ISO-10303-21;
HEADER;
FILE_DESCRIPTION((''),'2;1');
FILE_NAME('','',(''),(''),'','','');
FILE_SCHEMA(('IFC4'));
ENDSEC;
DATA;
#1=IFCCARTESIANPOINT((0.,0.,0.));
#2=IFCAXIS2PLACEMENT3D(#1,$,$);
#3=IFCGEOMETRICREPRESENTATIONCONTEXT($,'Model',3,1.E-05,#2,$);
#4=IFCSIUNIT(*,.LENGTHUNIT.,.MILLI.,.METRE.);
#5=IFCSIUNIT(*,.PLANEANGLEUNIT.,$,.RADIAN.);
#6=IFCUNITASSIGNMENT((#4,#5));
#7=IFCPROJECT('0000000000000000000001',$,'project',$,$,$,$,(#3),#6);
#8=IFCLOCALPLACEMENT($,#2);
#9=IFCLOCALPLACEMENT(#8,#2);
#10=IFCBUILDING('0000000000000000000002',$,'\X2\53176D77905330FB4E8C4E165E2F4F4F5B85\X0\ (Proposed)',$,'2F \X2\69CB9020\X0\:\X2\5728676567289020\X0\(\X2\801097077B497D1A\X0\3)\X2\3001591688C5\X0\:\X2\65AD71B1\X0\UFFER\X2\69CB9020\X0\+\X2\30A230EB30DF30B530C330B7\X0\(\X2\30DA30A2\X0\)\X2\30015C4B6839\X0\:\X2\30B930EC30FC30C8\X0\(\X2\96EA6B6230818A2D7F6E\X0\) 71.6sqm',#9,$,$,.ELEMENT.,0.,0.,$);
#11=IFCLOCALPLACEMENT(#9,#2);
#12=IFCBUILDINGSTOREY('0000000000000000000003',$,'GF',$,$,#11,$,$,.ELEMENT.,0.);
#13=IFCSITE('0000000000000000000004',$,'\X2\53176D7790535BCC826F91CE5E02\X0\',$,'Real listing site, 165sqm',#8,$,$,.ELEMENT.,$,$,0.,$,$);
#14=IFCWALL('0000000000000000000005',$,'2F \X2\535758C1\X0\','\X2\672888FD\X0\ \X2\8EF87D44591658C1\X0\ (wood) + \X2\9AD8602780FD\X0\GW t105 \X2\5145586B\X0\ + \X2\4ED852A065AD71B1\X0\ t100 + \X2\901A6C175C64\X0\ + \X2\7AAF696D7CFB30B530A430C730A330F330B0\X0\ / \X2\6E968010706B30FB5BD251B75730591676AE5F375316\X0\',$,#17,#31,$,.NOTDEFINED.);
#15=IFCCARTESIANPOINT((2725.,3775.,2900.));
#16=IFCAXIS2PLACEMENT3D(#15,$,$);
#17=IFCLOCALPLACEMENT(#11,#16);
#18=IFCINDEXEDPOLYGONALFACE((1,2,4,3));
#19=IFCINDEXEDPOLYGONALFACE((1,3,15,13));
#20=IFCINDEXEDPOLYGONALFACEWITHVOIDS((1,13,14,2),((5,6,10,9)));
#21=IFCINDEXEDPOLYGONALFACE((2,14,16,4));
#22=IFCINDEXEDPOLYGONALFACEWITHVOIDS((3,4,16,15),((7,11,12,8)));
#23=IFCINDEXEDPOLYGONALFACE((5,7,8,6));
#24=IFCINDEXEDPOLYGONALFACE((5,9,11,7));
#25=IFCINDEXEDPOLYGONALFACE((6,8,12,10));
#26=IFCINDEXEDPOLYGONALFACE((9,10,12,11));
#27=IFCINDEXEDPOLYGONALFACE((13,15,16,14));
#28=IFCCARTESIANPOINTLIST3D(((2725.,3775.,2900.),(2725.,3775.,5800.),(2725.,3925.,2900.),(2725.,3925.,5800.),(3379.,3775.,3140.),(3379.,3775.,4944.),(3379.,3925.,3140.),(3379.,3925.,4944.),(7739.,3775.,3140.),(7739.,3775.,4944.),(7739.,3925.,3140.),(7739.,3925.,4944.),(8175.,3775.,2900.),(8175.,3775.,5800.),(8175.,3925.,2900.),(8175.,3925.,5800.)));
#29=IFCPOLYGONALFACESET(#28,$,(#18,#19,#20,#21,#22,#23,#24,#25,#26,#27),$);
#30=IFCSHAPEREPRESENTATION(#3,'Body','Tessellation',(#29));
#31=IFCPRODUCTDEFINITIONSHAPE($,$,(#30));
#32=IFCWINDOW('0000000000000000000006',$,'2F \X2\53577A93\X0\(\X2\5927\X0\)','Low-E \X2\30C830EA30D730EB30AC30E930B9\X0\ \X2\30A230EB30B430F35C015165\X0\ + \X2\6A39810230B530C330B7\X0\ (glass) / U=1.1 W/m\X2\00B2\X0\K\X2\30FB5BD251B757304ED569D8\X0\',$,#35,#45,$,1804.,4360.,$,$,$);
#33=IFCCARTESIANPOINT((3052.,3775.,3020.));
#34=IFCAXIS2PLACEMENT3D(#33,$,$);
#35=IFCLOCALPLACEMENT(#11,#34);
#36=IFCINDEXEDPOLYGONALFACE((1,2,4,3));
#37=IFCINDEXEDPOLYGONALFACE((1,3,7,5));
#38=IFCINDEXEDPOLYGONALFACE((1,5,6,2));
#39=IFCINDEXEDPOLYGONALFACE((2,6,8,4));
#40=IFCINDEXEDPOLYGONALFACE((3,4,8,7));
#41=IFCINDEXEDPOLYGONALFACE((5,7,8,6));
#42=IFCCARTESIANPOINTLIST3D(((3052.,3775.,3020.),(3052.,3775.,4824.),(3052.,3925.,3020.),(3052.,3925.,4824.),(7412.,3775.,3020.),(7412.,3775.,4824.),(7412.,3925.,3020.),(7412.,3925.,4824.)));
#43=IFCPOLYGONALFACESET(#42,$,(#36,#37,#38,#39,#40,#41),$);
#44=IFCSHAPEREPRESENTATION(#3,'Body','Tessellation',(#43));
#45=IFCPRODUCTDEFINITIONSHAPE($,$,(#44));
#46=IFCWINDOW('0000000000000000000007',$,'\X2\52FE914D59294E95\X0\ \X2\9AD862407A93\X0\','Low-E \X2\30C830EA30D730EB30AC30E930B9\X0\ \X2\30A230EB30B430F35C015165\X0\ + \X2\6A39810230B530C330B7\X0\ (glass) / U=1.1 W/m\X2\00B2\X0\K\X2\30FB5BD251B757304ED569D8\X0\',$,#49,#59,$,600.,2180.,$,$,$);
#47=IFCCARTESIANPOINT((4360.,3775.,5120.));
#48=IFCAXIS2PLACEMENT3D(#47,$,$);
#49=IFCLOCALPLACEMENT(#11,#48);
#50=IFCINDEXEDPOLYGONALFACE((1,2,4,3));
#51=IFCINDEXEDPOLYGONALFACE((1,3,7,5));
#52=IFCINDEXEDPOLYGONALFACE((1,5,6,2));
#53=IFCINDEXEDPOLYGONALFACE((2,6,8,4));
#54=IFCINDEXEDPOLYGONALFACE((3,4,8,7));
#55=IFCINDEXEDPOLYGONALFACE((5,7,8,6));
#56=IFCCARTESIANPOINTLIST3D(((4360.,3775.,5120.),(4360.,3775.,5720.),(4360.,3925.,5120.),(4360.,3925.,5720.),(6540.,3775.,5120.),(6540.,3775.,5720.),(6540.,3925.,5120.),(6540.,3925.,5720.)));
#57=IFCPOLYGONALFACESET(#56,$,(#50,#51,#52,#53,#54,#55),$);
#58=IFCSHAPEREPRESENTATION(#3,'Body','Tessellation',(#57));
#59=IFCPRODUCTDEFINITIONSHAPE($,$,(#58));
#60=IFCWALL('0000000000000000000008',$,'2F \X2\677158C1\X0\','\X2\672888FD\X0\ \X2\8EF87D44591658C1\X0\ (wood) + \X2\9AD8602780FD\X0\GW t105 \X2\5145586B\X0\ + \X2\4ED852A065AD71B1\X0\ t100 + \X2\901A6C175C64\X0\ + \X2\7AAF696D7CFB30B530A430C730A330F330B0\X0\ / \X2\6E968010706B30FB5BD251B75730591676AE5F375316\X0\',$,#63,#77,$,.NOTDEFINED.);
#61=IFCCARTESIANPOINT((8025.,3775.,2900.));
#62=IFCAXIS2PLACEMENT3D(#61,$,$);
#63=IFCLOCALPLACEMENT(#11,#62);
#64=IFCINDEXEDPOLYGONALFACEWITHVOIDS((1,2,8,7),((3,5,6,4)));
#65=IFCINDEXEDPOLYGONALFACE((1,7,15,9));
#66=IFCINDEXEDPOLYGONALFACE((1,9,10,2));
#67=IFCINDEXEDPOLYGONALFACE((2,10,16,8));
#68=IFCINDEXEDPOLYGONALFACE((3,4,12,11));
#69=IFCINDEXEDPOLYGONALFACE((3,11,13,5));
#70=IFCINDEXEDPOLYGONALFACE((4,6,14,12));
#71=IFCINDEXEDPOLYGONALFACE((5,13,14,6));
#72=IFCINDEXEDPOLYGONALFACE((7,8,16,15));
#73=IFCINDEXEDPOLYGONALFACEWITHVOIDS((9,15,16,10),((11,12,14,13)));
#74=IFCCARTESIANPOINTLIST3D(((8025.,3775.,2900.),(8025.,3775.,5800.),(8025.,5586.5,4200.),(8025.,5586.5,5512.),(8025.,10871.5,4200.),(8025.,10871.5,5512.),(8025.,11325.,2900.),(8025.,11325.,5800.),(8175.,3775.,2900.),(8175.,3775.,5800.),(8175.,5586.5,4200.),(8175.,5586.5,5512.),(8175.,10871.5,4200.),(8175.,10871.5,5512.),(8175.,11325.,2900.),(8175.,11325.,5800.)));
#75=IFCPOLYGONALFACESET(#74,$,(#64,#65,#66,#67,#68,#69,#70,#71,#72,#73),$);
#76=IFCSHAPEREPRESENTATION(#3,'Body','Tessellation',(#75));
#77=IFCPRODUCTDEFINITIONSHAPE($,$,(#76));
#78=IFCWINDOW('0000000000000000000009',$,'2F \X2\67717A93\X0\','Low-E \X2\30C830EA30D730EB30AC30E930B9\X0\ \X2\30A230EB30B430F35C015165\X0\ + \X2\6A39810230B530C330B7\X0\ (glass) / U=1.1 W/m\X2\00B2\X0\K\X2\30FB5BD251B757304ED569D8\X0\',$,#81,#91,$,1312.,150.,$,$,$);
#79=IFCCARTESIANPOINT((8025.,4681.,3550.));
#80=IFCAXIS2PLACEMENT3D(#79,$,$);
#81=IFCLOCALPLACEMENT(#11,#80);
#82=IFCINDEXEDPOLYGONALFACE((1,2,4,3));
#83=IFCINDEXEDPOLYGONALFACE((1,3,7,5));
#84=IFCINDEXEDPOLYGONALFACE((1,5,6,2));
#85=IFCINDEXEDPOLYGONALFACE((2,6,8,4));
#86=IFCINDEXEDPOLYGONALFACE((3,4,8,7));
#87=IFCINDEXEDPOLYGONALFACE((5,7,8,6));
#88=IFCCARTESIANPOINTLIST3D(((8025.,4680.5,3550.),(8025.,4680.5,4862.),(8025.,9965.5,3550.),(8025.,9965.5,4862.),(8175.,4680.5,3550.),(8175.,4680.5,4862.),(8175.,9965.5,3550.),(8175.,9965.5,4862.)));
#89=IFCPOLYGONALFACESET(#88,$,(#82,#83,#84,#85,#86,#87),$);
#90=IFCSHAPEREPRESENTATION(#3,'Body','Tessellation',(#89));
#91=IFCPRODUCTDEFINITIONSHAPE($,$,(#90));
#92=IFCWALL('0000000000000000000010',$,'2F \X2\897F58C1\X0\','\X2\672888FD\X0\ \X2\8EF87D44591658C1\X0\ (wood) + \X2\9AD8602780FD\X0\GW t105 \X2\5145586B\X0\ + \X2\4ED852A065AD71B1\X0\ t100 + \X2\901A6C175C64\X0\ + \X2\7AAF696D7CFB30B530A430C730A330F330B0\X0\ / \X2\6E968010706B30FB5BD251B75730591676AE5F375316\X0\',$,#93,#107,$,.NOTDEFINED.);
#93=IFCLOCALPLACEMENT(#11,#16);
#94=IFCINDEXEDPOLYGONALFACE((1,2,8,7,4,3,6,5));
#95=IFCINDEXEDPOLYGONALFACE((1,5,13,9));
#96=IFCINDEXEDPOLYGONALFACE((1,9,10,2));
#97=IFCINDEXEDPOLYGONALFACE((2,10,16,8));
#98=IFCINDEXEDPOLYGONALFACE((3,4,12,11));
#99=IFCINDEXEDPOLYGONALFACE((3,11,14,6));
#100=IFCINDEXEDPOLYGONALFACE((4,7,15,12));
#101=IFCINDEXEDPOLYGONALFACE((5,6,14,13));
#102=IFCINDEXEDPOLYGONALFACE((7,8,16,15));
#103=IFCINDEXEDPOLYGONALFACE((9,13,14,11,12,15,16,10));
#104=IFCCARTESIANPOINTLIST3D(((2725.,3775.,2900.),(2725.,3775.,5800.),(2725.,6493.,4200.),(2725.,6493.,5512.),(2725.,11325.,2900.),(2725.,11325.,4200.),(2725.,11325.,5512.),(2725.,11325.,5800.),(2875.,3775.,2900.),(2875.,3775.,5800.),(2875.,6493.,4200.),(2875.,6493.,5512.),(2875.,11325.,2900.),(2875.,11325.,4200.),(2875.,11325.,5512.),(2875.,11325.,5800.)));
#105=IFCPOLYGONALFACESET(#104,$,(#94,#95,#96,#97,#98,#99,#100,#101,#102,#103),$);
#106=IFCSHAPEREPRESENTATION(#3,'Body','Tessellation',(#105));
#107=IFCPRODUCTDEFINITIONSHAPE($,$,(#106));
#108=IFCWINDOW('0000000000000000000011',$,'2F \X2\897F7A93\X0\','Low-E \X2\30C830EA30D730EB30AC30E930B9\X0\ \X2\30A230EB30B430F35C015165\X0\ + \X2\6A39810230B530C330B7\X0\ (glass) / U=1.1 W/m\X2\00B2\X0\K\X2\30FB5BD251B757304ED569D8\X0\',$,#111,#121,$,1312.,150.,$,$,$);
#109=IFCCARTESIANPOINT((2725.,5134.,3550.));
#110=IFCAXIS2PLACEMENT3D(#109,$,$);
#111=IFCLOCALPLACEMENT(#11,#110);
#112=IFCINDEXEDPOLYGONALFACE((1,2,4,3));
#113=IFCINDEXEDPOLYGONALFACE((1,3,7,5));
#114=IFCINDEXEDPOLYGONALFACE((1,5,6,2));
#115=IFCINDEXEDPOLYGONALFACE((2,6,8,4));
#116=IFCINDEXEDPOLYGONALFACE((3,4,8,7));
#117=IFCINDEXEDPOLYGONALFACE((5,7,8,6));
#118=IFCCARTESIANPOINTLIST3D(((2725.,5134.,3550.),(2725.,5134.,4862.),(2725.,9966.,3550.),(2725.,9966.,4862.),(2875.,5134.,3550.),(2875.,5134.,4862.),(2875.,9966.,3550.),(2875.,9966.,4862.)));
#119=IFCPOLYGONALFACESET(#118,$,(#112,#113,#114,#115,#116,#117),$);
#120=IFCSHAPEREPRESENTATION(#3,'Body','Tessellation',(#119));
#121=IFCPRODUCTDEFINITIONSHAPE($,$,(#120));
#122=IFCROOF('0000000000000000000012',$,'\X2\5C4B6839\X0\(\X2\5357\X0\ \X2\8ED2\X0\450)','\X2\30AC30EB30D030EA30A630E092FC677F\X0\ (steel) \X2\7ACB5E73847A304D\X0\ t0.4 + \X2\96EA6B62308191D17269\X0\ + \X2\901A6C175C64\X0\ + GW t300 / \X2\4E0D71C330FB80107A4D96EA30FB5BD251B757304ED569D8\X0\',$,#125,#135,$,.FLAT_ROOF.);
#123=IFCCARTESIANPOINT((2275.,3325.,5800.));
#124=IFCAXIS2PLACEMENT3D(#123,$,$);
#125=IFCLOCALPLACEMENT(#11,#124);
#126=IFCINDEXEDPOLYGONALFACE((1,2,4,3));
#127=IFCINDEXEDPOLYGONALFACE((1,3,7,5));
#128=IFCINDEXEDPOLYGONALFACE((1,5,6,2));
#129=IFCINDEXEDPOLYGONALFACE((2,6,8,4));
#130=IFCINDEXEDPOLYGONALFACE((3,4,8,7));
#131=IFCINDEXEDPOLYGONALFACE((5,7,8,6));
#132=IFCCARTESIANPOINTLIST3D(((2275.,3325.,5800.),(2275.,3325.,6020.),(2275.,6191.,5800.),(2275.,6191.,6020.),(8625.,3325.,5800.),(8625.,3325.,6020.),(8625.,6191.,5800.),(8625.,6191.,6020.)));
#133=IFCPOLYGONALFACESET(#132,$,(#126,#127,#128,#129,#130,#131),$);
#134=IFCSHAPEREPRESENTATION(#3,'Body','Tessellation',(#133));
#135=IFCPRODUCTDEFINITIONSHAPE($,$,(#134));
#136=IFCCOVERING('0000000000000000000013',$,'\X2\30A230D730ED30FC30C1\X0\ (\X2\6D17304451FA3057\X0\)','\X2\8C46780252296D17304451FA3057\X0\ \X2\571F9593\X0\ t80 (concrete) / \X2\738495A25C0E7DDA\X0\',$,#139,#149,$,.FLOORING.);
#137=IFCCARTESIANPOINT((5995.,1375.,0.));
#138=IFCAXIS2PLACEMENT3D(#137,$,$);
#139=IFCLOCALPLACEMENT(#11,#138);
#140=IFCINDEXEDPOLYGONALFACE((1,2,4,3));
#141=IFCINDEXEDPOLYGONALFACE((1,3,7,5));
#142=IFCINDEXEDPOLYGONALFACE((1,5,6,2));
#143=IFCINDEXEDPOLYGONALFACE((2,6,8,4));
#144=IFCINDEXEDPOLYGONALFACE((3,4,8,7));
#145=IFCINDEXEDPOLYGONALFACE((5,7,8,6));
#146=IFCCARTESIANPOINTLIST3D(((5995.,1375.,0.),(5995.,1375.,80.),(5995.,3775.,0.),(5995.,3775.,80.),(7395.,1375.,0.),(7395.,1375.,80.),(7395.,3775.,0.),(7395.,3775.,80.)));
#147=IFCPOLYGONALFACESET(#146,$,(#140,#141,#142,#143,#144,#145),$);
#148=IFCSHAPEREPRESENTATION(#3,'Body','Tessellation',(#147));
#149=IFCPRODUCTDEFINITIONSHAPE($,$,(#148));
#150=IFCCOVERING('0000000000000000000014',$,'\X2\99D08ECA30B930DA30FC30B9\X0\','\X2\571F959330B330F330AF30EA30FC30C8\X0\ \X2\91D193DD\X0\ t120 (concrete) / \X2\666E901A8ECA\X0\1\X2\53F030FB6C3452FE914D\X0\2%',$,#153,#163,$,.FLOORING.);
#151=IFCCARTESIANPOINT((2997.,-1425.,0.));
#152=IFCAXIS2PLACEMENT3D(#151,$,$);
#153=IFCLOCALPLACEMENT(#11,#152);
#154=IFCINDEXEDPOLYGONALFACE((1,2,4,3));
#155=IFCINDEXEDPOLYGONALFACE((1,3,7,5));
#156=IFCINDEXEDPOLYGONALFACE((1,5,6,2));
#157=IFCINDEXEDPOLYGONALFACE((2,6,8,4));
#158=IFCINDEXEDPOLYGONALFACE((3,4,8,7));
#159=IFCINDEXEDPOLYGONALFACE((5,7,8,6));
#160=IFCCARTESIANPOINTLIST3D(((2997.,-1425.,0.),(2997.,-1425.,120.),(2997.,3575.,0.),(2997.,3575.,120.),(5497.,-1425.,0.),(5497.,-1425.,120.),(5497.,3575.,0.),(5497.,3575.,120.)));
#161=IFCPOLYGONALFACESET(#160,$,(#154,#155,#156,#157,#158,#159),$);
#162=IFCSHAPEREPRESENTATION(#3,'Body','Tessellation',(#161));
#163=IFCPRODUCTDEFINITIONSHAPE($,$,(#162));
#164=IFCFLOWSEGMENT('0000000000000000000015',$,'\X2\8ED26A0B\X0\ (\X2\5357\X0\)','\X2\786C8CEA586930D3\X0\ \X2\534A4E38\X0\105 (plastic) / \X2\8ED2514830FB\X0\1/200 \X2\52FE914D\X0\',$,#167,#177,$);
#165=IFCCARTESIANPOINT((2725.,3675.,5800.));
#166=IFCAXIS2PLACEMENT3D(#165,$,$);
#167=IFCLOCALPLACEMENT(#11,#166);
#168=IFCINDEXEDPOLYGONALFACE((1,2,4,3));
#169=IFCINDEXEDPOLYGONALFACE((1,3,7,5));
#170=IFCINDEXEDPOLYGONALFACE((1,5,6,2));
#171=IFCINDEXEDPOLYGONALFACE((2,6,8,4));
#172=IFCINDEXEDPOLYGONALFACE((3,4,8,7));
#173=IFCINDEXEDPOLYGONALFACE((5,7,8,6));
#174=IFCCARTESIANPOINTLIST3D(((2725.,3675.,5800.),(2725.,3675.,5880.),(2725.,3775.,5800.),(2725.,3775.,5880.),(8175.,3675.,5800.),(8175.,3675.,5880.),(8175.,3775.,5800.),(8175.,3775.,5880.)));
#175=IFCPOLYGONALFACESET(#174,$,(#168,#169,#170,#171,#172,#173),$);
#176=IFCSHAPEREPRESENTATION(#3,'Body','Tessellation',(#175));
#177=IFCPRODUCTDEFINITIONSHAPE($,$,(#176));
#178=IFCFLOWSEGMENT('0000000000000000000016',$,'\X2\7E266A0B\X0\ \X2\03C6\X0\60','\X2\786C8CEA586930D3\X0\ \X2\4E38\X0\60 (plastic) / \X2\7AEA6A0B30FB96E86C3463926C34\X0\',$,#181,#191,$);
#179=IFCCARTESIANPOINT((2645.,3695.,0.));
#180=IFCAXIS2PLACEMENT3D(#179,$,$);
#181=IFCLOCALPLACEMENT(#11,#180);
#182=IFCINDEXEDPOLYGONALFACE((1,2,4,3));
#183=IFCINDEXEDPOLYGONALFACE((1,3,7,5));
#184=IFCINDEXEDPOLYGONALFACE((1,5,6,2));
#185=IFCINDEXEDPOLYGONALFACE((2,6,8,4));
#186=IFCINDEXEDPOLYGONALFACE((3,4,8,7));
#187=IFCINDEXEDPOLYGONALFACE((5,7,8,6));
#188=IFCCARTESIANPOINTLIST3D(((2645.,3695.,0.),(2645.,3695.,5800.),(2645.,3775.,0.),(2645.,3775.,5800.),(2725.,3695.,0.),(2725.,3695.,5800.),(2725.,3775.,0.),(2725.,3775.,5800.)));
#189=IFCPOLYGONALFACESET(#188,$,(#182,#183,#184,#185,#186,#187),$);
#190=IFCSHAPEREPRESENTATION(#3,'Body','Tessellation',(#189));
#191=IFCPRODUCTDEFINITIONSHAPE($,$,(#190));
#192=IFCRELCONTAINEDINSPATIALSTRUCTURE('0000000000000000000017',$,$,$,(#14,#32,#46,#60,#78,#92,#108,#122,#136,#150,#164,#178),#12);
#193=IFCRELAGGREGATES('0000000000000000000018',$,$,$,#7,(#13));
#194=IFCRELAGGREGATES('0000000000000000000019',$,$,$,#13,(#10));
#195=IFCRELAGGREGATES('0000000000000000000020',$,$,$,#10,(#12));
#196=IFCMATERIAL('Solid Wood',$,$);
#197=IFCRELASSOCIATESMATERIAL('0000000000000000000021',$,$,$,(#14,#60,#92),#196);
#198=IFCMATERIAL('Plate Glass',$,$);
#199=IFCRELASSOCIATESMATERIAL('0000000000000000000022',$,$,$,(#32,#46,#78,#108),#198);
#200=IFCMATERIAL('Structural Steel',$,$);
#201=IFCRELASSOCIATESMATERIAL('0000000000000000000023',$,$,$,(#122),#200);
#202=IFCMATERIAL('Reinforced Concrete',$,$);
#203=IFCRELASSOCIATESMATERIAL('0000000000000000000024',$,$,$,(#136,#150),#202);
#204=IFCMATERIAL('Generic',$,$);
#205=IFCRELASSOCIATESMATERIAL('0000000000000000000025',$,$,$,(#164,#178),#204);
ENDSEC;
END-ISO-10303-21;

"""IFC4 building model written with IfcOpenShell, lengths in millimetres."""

from ifc_helpers import new_model, si_unit, frame, frame_2d, origin, place, context, project, spatial, rectangle, extrude, material, element, fill, save


model = new_model("IFC4")

# Units and contexts
model_context = context("Model", 3, precision=1e-05, world=origin())
ifc_project = project(units=[si_unit("LENGTHUNIT", "METRE", prefix="MILLI"), si_unit("PLANEANGLEUNIT", "RADIAN")], contexts=[model_context])

# Site, building, storey
site_placement = place(None, origin())
site = spatial("IfcSite", under=ifc_project, at=site_placement, Name="北海道富良野市", ObjectType="Real listing site, 165sqm", CompositionType="ELEMENT", RefElevation=0.0)
building_placement = place(site_placement, origin())
building = spatial("IfcBuilding", under=site, at=building_placement, Name="北海道・二世帯住宅 (Proposed)", ObjectType="2F 構造:在来木造(耐震等級3)、外装:断熱UFFER構造+アルミサッシ(ペア)、屋根:スレート(雪止め設置) 71.6sqm", CompositionType="ELEMENT", ElevationOfRefHeight=0.0, ElevationOfTerrain=0.0)
storey_placement = place(building_placement, origin())
storey = spatial("IfcBuildingStorey", under=building, at=storey_placement, Name="GF", CompositionType="ELEMENT", Elevation=0.0)

# Shared definitions
ifc_material_1 = material(Name="Solid Wood")

# Shared definitions
ifc_material_2 = material(Name="Reinforced Concrete")

# Shared definitions
ifc_material_3 = material(Name="Plate Glass")

# Wall, openings, windows
wall_1_placement = place(storey_placement, frame((2725.0, 3775.0, 2900.0)))
wall_1 = element("IfcWall", 1, at=wall_1_placement, inside=storey, material=ifc_material_1, Name="2F 南壁", Description="木製 軸組外壁 (wood) + 高性能GW t105 充填 + 付加断熱 t100 + 通気層 + 窯業系サイディング / 準耐火・寒冷地外皮強化", PredefinedType="NOTDEFINED", context=model_context, shape_type="SweptSolid", body=[
    extrude(rectangle(XDim=5450.0, YDim=150.0, at=frame_2d((2725.0, 75.0))), frame((2725.0, 3775.0, 2900.0)), (0.0, 0.0, 1.0), 2900.0),
])
opening_1_placement = place(storey_placement, frame((3052.0, 3775.0, 3020.0)))
opening_1 = element("IfcOpeningElement", 2, at=opening_1_placement, cuts=wall_1, PredefinedType="NOTDEFINED", context=model_context, shape_type="SweptSolid", body=[
    extrude(rectangle(XDim=4360.0, YDim=150.0, at=frame_2d((2180.0, 75.0))), frame((3052.0, 3775.0, 3020.0)), (0.0, 0.0, 1.0), 1804.0),
])
opening_2_placement = place(storey_placement, frame((4360.0, 3775.0, 5120.0)))
opening_2 = element("IfcOpeningElement", 3, at=opening_2_placement, cuts=wall_1, PredefinedType="NOTDEFINED", context=model_context, shape_type="SweptSolid", body=[
    extrude(rectangle(XDim=2180.0, YDim=150.0, at=frame_2d((1090.0, 75.0))), frame((4360.0, 3775.0, 5120.0)), (0.0, 0.0, 1.0), 600.0),
])
window_1_placement = place(storey_placement, frame((3052.0, 3775.0, 3020.0)))
window_1 = element("IfcWindow", 4, at=window_1_placement, inside=storey, material=ifc_material_3, Name="2F 南窓(大)", Description="Low-E トリプルガラス アルゴン封入 + 樹脂サッシ (glass) / U=1.1 W/m²K・寒冷地仕様", OverallHeight=1804.0, OverallWidth=4360.0, context=model_context, shape_type="SweptSolid", body=[
    extrude(rectangle(XDim=4360.0, YDim=150.0, at=frame_2d((2180.0, 75.0))), frame((3052.0, 3775.0, 3020.0)), (0.0, 0.0, 1.0), 1804.0),
])
fill(opening_1, window_1)
window_2_placement = place(storey_placement, frame((4360.0, 3775.0, 5120.0)))
window_2 = element("IfcWindow", 5, at=window_2_placement, inside=storey, material=ifc_material_3, Name="勾配天井 高所窓", Description="Low-E トリプルガラス アルゴン封入 + 樹脂サッシ (glass) / U=1.1 W/m²K・寒冷地仕様", OverallHeight=600.0, OverallWidth=2180.0, context=model_context, shape_type="SweptSolid", body=[
    extrude(rectangle(XDim=2180.0, YDim=150.0, at=frame_2d((1090.0, 75.0))), frame((4360.0, 3775.0, 5120.0)), (0.0, 0.0, 1.0), 600.0),
])
fill(opening_2, window_2)

# Walls, openings, windows
wall_2_placement = place(storey_placement, frame((8025.0, 3775.0, 2900.0)))
wall_2 = element("IfcWall", 6, at=wall_2_placement, inside=storey, material=ifc_material_1, Name="2F 東壁", Description="木製 軸組外壁 (wood) + 高性能GW t105 充填 + 付加断熱 t100 + 通気層 + 窯業系サイディング / 準耐火・寒冷地外皮強化", PredefinedType="NOTDEFINED", context=model_context, shape_type="SweptSolid", body=[
    extrude(rectangle(XDim=150.0, YDim=7550.0, at=frame_2d((75.0, 3775.0))), frame((8025.0, 3775.0, 2900.0)), (0.0, 0.0, 1.0), 2900.0),
])
opening_3_placement = place(storey_placement, frame((8025.0, 4681.0, 3550.0)))
opening_3 = element("IfcOpeningElement", 7, at=opening_3_placement, cuts=wall_2, PredefinedType="NOTDEFINED", context=model_context, shape_type="SweptSolid", body=[
    extrude(rectangle(XDim=150.0, YDim=5285.0, at=frame_2d((75.0, 2642.0))), frame((8025.0, 4681.0, 3550.0)), (0.0, 0.0, 1.0), 1312.0),
])
window_3_placement = place(storey_placement, frame((8025.0, 4681.0, 3550.0)))
window_3 = element("IfcWindow", 8, at=window_3_placement, inside=storey, material=ifc_material_3, Name="2F 東窓", Description="Low-E トリプルガラス アルゴン封入 + 樹脂サッシ (glass) / U=1.1 W/m²K・寒冷地仕様", OverallHeight=1312.0, OverallWidth=150.0, context=model_context, shape_type="SweptSolid", body=[
    extrude(rectangle(XDim=150.0, YDim=5285.0, at=frame_2d((75.0, 2642.0))), frame((8025.0, 4681.0, 3550.0)), (0.0, 0.0, 1.0), 1312.0),
])
fill(opening_3, window_3)
wall_3_placement = place(storey_placement, frame((2725.0, 3775.0, 2900.0)))
wall_3 = element("IfcWall", 9, at=wall_3_placement, inside=storey, material=ifc_material_1, Name="2F 西壁", Description="木製 軸組外壁 (wood) + 高性能GW t105 充填 + 付加断熱 t100 + 通気層 + 窯業系サイディング / 準耐火・寒冷地外皮強化", PredefinedType="NOTDEFINED", context=model_context, shape_type="SweptSolid", body=[
    extrude(rectangle(XDim=150.0, YDim=7550.0, at=frame_2d((75.0, 3775.0))), frame((2725.0, 3775.0, 2900.0)), (0.0, 0.0, 1.0), 2900.0),
])
opening_4_placement = place(storey_placement, frame((2725.0, 5134.0, 3550.0)))
opening_4 = element("IfcOpeningElement", 10, at=opening_4_placement, cuts=wall_3, PredefinedType="NOTDEFINED", context=model_context, shape_type="SweptSolid", body=[
    extrude(rectangle(XDim=150.0, YDim=4832.0, at=frame_2d((75.0, 2416.0))), frame((2725.0, 5134.0, 3550.0)), (0.0, 0.0, 1.0), 1312.0),
])
window_4_placement = place(storey_placement, frame((2725.0, 5134.0, 3550.0)))
window_4 = element("IfcWindow", 11, at=window_4_placement, inside=storey, material=ifc_material_3, Name="2F 西窓", Description="Low-E トリプルガラス アルゴン封入 + 樹脂サッシ (glass) / U=1.1 W/m²K・寒冷地仕様", OverallHeight=1312.0, OverallWidth=150.0, context=model_context, shape_type="SweptSolid", body=[
    extrude(rectangle(XDim=150.0, YDim=4832.0, at=frame_2d((75.0, 2416.0))), frame((2725.0, 5134.0, 3550.0)), (0.0, 0.0, 1.0), 1312.0),
])
fill(opening_4, window_4)

# Roof
ifc_material_4 = material(Name="Structural Steel")
for number, where, name in (
    (12, (2275.0, 3325.0, 5800.0), "屋根(南 軒450)"),
):
    element("IfcRoof", number, at=place(storey_placement, frame(where)), inside=storey, material=ifc_material_4, Name=name, Description="ガルバリウム鋼板 (steel) 立平葺き t0.4 + 雪止め金物 + 通気層 + GW t300 / 不燃・耐積雪・寒冷地仕様", PredefinedType="FLAT_ROOF", context=model_context, shape_type="SweptSolid", body=[
        extrude(rectangle(XDim=6350.0, YDim=2866.0, at=frame_2d((3175.0, 1433.0))), frame((2275.0, 3325.0, 5800.0)), (0.0, 0.0, 1.0), 220.0),
    ])

# Coverings
covering_1_placement = place(storey_placement, frame((5995.0, 1375.0, 0.0)))
element("IfcCovering", 13, at=covering_1_placement, inside=storey, material=ifc_material_2, Name="アプローチ (洗い出し)", Description="豆砂利洗い出し 土間 t80 (concrete) / 玄関導線", PredefinedType="FLOORING", context=model_context, shape_type="SweptSolid", body=[
    extrude(rectangle(XDim=1400.0, YDim=2400.0, at=frame_2d((700.0, 1200.0))), frame((5995.0, 1375.0, 0.0)), (0.0, 0.0, 1.0), 80.0),
])
covering_2_placement = place(storey_placement, frame((2997.0, -1425.0, 0.0)))
element("IfcCovering", 14, at=covering_2_placement, inside=storey, material=ifc_material_2, Name="駐車スペース", Description="土間コンクリート 金鏝 t120 (concrete) / 普通車1台・水勾配2%", PredefinedType="FLOORING", context=model_context, shape_type="SweptSolid", body=[
    extrude(rectangle(XDim=2500.0, YDim=5000.0, at=frame_2d((1250.0, 2500.0))), frame((2997.0, -1425.0, 0.0)), (0.0, 0.0, 1.0), 120.0),
])

# Flow segments
ifc_material_5 = material(Name="Generic")
flow_segment_1_placement = place(storey_placement, frame((2725.0, 3675.0, 5800.0)))
element("IfcFlowSegment", 15, at=flow_segment_1_placement, inside=storey, material=ifc_material_5, Name="軒樋 (南)", Description="硬質塩ビ 半丸105 (plastic) / 軒先・1/200 勾配", context=model_context, shape_type="SweptSolid", body=[
    extrude(rectangle(XDim=5450.0, YDim=100.0, at=frame_2d((2725.0, 50.0))), frame((2725.0, 3675.0, 5800.0)), (0.0, 0.0, 1.0), 80.0),
])
flow_segment_2_placement = place(storey_placement, frame((2645.0, 3695.0, 0.0)))
element("IfcFlowSegment", 16, at=flow_segment_2_placement, inside=storey, material=ifc_material_5, Name="縦樋 φ60", Description="硬質塩ビ 丸60 (plastic) / 竪樋・雨水排水", context=model_context, shape_type="SweptSolid", body=[
    extrude(rectangle(XDim=80.0, YDim=80.0, at=frame_2d((40.0, 40.0))), frame((2645.0, 3695.0, 0.0)), (0.0, 0.0, 1.0), 5800.0),
])

save(model, "model.ifc")
